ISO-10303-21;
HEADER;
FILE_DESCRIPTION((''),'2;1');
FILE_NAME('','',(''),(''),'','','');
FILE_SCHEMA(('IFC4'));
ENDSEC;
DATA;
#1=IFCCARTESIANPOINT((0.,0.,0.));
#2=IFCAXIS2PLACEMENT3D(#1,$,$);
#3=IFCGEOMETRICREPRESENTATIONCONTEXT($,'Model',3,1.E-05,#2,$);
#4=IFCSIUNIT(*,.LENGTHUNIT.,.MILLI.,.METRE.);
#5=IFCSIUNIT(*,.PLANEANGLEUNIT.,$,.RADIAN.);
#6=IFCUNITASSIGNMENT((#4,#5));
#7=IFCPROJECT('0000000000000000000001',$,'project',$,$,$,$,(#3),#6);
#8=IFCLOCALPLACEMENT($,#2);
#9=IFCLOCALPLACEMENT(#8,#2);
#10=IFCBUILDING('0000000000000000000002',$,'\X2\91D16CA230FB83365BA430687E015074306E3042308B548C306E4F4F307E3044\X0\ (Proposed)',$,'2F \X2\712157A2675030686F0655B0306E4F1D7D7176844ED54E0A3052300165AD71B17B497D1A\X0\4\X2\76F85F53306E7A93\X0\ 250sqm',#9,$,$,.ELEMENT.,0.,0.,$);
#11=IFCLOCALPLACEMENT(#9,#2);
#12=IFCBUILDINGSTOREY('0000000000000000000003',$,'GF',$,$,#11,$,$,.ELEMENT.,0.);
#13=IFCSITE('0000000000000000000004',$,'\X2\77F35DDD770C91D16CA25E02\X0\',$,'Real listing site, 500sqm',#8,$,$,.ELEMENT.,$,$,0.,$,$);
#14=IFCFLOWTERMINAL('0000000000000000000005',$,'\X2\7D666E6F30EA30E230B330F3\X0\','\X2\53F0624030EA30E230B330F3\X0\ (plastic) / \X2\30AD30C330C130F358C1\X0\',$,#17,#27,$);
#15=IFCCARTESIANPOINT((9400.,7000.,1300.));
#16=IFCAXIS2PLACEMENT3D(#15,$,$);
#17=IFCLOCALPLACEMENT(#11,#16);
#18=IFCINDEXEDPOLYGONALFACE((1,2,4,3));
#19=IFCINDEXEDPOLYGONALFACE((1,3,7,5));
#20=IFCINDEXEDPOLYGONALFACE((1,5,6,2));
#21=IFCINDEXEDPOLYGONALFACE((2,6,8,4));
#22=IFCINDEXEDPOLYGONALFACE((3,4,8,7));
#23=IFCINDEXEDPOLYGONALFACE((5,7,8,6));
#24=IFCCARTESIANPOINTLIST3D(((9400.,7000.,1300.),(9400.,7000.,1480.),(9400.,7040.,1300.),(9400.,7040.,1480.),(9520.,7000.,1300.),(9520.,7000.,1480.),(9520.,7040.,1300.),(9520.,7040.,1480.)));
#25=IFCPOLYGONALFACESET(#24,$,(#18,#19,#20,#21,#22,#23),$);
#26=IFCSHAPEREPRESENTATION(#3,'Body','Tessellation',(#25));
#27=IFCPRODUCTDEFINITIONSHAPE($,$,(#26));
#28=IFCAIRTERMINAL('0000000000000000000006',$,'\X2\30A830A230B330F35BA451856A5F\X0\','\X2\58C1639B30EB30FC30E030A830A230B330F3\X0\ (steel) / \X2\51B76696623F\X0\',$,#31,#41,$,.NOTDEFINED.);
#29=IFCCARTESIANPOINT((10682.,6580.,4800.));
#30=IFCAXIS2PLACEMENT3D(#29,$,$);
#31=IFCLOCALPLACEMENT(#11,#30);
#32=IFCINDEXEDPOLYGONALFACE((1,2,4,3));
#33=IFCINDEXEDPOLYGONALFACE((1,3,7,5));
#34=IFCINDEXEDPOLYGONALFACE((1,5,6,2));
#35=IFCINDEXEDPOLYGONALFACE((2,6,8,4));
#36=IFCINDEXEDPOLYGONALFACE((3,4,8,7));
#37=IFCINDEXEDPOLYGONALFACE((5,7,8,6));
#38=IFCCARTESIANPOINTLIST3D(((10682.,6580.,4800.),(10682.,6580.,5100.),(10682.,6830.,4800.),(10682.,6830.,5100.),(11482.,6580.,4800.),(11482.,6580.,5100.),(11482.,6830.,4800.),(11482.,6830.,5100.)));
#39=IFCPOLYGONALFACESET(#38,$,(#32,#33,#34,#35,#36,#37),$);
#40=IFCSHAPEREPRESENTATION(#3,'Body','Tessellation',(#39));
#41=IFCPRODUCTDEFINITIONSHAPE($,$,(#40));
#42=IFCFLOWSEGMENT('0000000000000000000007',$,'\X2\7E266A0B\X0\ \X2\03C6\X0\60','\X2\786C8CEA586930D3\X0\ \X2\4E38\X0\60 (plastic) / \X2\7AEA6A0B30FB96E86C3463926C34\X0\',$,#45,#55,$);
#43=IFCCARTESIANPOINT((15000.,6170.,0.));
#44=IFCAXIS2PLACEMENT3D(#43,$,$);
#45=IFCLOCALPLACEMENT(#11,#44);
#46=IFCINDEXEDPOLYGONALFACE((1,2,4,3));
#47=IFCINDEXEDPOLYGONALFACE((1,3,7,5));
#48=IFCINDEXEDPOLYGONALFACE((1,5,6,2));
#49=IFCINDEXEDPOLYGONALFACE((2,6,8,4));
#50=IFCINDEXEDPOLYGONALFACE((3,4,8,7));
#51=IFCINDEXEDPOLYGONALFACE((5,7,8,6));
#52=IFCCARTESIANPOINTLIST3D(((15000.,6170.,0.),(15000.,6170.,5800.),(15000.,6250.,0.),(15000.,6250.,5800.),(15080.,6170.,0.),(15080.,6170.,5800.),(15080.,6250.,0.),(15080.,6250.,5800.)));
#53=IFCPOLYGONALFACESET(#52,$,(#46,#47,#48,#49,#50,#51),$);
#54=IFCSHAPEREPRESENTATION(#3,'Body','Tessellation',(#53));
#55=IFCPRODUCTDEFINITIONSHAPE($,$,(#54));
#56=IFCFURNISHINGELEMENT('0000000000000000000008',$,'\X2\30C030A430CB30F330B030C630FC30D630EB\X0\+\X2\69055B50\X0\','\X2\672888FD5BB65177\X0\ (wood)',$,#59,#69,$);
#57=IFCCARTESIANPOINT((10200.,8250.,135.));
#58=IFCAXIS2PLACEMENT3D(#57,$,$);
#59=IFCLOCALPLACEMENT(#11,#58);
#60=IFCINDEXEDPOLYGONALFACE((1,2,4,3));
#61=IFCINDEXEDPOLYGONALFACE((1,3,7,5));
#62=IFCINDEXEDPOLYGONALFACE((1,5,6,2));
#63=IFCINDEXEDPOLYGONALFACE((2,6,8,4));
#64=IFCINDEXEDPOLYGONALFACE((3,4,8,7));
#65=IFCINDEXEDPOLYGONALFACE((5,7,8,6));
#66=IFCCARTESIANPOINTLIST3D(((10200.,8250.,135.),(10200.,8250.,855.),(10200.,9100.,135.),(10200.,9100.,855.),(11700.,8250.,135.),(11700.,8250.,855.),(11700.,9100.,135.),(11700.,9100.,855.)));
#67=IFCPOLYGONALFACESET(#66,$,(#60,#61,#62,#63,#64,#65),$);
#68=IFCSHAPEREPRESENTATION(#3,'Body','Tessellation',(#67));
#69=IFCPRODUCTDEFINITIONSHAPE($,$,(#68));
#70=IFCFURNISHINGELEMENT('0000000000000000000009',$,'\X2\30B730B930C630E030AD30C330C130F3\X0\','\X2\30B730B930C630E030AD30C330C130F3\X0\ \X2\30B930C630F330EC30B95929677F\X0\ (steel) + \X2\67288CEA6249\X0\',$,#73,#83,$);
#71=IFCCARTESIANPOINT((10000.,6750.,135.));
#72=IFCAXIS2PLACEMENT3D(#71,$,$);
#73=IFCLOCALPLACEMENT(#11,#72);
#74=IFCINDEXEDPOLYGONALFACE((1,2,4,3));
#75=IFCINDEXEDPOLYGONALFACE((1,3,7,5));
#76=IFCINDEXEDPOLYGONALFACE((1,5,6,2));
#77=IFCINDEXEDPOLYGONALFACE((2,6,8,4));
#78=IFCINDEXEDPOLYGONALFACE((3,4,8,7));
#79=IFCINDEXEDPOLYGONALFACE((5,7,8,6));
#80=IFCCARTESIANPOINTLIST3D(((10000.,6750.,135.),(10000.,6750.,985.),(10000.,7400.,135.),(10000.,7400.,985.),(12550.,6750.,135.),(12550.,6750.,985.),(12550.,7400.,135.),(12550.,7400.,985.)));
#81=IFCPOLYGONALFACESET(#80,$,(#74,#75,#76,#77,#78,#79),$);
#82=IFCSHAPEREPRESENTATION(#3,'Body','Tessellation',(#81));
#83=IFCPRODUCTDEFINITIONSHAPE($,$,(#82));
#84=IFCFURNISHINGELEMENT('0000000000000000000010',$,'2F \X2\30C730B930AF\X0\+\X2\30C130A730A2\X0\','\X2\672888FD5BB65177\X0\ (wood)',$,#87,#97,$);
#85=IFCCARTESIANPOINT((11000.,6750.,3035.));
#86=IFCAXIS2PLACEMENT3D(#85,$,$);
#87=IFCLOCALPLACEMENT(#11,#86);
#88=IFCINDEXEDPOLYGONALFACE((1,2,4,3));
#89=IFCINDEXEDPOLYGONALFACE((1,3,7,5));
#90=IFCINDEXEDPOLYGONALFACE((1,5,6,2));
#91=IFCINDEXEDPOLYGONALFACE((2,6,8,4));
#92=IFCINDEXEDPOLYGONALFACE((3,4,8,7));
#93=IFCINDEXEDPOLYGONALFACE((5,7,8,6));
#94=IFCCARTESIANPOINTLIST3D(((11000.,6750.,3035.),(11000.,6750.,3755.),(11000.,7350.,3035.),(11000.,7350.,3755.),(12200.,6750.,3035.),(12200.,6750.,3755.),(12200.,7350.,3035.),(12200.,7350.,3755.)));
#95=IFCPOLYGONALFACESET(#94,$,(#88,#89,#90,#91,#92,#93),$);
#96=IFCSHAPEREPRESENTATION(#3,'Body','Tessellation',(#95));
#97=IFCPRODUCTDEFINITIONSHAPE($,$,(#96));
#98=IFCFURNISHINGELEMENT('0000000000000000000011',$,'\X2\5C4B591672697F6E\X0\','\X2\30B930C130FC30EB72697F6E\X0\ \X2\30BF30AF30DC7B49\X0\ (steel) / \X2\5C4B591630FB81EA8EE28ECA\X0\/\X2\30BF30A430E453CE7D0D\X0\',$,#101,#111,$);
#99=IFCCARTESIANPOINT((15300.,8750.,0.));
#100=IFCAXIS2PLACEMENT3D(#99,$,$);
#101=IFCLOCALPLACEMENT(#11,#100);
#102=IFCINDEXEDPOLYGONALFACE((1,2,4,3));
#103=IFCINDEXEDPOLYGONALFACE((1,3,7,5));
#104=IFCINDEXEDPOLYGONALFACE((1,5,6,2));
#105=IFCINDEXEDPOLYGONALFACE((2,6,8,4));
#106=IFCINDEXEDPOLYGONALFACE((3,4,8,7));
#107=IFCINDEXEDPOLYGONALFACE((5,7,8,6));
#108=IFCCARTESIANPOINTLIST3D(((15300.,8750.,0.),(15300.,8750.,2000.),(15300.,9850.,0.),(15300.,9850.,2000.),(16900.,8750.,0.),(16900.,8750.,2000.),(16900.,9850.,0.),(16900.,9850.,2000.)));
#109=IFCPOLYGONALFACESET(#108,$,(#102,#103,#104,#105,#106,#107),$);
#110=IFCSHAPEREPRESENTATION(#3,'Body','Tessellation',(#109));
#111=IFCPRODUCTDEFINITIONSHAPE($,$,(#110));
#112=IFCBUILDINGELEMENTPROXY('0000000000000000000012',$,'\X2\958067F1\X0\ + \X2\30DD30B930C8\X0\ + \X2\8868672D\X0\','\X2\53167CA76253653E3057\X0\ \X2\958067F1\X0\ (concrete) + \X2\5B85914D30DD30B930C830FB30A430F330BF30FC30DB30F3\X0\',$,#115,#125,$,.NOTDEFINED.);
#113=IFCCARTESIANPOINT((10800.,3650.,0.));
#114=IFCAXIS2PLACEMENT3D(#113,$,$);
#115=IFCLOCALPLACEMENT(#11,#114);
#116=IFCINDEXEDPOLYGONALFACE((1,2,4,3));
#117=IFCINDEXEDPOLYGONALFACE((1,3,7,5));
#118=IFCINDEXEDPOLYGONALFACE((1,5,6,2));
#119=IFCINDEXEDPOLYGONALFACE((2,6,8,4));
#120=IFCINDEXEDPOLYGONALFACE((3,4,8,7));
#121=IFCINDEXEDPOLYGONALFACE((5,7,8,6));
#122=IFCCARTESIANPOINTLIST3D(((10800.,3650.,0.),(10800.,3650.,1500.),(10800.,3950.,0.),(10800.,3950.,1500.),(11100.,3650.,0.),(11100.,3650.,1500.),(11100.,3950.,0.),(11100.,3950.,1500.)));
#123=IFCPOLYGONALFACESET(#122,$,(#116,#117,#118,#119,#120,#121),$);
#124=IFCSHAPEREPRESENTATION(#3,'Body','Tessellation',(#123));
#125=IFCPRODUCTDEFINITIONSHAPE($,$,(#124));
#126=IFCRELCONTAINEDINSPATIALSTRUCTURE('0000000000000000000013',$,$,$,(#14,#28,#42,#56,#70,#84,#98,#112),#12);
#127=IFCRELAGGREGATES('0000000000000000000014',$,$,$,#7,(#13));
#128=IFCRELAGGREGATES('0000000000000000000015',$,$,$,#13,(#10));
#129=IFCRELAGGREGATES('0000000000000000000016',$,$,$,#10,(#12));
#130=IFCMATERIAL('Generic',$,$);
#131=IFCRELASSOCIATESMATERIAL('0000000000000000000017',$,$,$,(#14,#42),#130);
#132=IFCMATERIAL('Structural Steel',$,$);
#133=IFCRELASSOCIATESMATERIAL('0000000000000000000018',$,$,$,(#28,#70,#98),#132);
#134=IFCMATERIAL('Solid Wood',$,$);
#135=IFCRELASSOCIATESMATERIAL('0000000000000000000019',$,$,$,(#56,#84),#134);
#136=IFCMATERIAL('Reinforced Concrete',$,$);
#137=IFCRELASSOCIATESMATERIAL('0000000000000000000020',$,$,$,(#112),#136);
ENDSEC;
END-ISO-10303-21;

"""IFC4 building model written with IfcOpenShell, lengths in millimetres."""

from ifc_helpers import new_model, si_unit, frame, frame_2d, origin, place, context, project, spatial, rectangle, extrude, material, element, save


model = new_model("IFC4")

# Units and contexts
model_context = context("Model", 3, precision=1e-05, world=origin())
ifc_project = project(units=[si_unit("LENGTHUNIT", "METRE", prefix="MILLI"), si_unit("PLANEANGLEUNIT", "RADIAN")], contexts=[model_context])

# Site, building, storey
site_placement = place(None, origin())
site = spatial("IfcSite", under=ifc_project, at=site_placement, Name="石川県金沢市", ObjectType="Real listing site, 500sqm", CompositionType="ELEMENT", RefElevation=0.0)
building_placement = place(site_placement, origin())
building = spatial("IfcBuilding", under=site, at=building_placement, Name="金沢・茶室と縁側のある和の住まい (Proposed)", ObjectType="2F 無垢材と漆喰の伝統的仕上げ、断熱等級4相当の窓 250sqm", CompositionType="ELEMENT", ElevationOfRefHeight=0.0, ElevationOfTerrain=0.0)
storey_placement = place(building_placement, origin())
storey = spatial("IfcBuildingStorey", under=building, at=storey_placement, Name="GF", CompositionType="ELEMENT", Elevation=0.0)

# Shared definitions
ifc_material_1 = material(Name="Solid Wood")

# Shared definitions
ifc_material_2 = material(Name="Reinforced Concrete")

# Shared definitions
ifc_material_3 = material(Name="Structural Steel")

# Flow terminal
ifc_material_4 = material(Name="Generic")
flow_terminal_1_placement = place(storey_placement, frame((9400.0, 7000.0, 1300.0)))
element("IfcFlowTerminal", 1, at=flow_terminal_1_placement, inside=storey, material=ifc_material_4, Name="給湯リモコン", Description="台所リモコン (plastic) / キッチン壁", context=model_context, shape_type="SweptSolid", body=[
    extrude(rectangle(XDim=120.0, YDim=40.0, at=frame_2d((60.0, 20.0))), frame((9400.0, 7000.0, 1300.0)), (0.0, 0.0, 1.0), 180.0),
])

# Air terminal
air_terminal_placement = place(storey_placement, frame((10682.0, 6580.0, 4800.0)))
element("IfcAirTerminal", 2, at=air_terminal_placement, inside=storey, material=ifc_material_3, Name="エアコン室内機", Description="壁掛ルームエアコン (steel) / 冷暖房", PredefinedType="NOTDEFINED", context=model_context, shape_type="SweptSolid", body=[
    extrude(rectangle(XDim=800.0, YDim=250.0, at=frame_2d((400.0, 125.0))), frame((10682.0, 6580.0, 4800.0)), (0.0, 0.0, 1.0), 300.0),
])

# Flow segment
flow_segment_placement = place(storey_placement, frame((15000.0, 6170.0, 0.0)))
element("IfcFlowSegment", 3, at=flow_segment_placement, inside=storey, material=ifc_material_4, Name="縦樋 φ60", Description="硬質塩ビ 丸60 (plastic) / 竪樋・雨水排水", context=model_context, shape_type="SweptSolid", body=[
    extrude(rectangle(XDim=80.0, YDim=80.0, at=frame_2d((40.0, 40.0))), frame((15000.0, 6170.0, 0.0)), (0.0, 0.0, 1.0), 5800.0),
])

# Furnishing elements
furnishing_1_placement = place(storey_placement, frame((10200.0, 8250.0, 135.0)))
element("IfcFurnishingElement", 4, at=furnishing_1_placement, inside=storey, material=ifc_material_1, Name="ダイニングテーブル+椅子", Description="木製家具 (wood)", context=model_context, shape_type="SweptSolid", body=[
    extrude(rectangle(XDim=1500.0, YDim=850.0, at=frame_2d((750.0, 425.0))), frame((10200.0, 8250.0, 135.0)), (0.0, 0.0, 1.0), 720.0),
])
furnishing_2_placement = place(storey_placement, frame((10000.0, 6750.0, 135.0)))
element("IfcFurnishingElement", 5, at=furnishing_2_placement, inside=storey, material=ifc_material_3, Name="システムキッチン", Description="システムキッチン ステンレス天板 (steel) + 木質扉", context=model_context, shape_type="SweptSolid", body=[
    extrude(rectangle(XDim=2550.0, YDim=650.0, at=frame_2d((1275.0, 325.0))), frame((10000.0, 6750.0, 135.0)), (0.0, 0.0, 1.0), 850.0),
])
furnishing_3_placement = place(storey_placement, frame((11000.0, 6750.0, 3035.0)))
element("IfcFurnishingElement", 6, at=furnishing_3_placement, inside=storey, material=ifc_material_1, Name="2F デスク+チェア", Description="木製家具 (wood)", context=model_context, shape_type="SweptSolid", body=[
    extrude(rectangle(XDim=1200.0, YDim=600.0, at=frame_2d((600.0, 300.0))), frame((11000.0, 6750.0, 3035.0)), (0.0, 0.0, 1.0), 720.0),
])
furnishing_4_placement = place(storey_placement, frame((15300.0, 8750.0, 0.0)))
element("IfcFurnishingElement", 7, at=furnishing_4_placement, inside=storey, material=ifc_material_3, Name="屋外物置", Description="スチール物置 タクボ等 (steel) / 屋外・自転車/タイヤ収納", context=model_context, shape_type="SweptSolid", body=[
    extrude(rectangle(XDim=1600.0, YDim=1100.0, at=frame_2d((800.0, 550.0))), frame((15300.0, 8750.0, 0.0)), (0.0, 0.0, 1.0), 2000.0),
])

# Building element proxy
proxy_placement = place(storey_placement, frame((10800.0, 3650.0, 0.0)))
element("IfcBuildingElementProxy", 8, at=proxy_placement, inside=storey, material=ifc_material_2, Name="門柱 + ポスト + 表札", Description="化粧打放し 門柱 (concrete) + 宅配ポスト・インターホン", PredefinedType="NOTDEFINED", context=model_context, shape_type="SweptSolid", body=[
    extrude(rectangle(XDim=300.0, YDim=300.0, at=frame_2d((150.0, 150.0))), frame((10800.0, 3650.0, 0.0)), (0.0, 0.0, 1.0), 1500.0),
])

save(model, "model.ifc")
